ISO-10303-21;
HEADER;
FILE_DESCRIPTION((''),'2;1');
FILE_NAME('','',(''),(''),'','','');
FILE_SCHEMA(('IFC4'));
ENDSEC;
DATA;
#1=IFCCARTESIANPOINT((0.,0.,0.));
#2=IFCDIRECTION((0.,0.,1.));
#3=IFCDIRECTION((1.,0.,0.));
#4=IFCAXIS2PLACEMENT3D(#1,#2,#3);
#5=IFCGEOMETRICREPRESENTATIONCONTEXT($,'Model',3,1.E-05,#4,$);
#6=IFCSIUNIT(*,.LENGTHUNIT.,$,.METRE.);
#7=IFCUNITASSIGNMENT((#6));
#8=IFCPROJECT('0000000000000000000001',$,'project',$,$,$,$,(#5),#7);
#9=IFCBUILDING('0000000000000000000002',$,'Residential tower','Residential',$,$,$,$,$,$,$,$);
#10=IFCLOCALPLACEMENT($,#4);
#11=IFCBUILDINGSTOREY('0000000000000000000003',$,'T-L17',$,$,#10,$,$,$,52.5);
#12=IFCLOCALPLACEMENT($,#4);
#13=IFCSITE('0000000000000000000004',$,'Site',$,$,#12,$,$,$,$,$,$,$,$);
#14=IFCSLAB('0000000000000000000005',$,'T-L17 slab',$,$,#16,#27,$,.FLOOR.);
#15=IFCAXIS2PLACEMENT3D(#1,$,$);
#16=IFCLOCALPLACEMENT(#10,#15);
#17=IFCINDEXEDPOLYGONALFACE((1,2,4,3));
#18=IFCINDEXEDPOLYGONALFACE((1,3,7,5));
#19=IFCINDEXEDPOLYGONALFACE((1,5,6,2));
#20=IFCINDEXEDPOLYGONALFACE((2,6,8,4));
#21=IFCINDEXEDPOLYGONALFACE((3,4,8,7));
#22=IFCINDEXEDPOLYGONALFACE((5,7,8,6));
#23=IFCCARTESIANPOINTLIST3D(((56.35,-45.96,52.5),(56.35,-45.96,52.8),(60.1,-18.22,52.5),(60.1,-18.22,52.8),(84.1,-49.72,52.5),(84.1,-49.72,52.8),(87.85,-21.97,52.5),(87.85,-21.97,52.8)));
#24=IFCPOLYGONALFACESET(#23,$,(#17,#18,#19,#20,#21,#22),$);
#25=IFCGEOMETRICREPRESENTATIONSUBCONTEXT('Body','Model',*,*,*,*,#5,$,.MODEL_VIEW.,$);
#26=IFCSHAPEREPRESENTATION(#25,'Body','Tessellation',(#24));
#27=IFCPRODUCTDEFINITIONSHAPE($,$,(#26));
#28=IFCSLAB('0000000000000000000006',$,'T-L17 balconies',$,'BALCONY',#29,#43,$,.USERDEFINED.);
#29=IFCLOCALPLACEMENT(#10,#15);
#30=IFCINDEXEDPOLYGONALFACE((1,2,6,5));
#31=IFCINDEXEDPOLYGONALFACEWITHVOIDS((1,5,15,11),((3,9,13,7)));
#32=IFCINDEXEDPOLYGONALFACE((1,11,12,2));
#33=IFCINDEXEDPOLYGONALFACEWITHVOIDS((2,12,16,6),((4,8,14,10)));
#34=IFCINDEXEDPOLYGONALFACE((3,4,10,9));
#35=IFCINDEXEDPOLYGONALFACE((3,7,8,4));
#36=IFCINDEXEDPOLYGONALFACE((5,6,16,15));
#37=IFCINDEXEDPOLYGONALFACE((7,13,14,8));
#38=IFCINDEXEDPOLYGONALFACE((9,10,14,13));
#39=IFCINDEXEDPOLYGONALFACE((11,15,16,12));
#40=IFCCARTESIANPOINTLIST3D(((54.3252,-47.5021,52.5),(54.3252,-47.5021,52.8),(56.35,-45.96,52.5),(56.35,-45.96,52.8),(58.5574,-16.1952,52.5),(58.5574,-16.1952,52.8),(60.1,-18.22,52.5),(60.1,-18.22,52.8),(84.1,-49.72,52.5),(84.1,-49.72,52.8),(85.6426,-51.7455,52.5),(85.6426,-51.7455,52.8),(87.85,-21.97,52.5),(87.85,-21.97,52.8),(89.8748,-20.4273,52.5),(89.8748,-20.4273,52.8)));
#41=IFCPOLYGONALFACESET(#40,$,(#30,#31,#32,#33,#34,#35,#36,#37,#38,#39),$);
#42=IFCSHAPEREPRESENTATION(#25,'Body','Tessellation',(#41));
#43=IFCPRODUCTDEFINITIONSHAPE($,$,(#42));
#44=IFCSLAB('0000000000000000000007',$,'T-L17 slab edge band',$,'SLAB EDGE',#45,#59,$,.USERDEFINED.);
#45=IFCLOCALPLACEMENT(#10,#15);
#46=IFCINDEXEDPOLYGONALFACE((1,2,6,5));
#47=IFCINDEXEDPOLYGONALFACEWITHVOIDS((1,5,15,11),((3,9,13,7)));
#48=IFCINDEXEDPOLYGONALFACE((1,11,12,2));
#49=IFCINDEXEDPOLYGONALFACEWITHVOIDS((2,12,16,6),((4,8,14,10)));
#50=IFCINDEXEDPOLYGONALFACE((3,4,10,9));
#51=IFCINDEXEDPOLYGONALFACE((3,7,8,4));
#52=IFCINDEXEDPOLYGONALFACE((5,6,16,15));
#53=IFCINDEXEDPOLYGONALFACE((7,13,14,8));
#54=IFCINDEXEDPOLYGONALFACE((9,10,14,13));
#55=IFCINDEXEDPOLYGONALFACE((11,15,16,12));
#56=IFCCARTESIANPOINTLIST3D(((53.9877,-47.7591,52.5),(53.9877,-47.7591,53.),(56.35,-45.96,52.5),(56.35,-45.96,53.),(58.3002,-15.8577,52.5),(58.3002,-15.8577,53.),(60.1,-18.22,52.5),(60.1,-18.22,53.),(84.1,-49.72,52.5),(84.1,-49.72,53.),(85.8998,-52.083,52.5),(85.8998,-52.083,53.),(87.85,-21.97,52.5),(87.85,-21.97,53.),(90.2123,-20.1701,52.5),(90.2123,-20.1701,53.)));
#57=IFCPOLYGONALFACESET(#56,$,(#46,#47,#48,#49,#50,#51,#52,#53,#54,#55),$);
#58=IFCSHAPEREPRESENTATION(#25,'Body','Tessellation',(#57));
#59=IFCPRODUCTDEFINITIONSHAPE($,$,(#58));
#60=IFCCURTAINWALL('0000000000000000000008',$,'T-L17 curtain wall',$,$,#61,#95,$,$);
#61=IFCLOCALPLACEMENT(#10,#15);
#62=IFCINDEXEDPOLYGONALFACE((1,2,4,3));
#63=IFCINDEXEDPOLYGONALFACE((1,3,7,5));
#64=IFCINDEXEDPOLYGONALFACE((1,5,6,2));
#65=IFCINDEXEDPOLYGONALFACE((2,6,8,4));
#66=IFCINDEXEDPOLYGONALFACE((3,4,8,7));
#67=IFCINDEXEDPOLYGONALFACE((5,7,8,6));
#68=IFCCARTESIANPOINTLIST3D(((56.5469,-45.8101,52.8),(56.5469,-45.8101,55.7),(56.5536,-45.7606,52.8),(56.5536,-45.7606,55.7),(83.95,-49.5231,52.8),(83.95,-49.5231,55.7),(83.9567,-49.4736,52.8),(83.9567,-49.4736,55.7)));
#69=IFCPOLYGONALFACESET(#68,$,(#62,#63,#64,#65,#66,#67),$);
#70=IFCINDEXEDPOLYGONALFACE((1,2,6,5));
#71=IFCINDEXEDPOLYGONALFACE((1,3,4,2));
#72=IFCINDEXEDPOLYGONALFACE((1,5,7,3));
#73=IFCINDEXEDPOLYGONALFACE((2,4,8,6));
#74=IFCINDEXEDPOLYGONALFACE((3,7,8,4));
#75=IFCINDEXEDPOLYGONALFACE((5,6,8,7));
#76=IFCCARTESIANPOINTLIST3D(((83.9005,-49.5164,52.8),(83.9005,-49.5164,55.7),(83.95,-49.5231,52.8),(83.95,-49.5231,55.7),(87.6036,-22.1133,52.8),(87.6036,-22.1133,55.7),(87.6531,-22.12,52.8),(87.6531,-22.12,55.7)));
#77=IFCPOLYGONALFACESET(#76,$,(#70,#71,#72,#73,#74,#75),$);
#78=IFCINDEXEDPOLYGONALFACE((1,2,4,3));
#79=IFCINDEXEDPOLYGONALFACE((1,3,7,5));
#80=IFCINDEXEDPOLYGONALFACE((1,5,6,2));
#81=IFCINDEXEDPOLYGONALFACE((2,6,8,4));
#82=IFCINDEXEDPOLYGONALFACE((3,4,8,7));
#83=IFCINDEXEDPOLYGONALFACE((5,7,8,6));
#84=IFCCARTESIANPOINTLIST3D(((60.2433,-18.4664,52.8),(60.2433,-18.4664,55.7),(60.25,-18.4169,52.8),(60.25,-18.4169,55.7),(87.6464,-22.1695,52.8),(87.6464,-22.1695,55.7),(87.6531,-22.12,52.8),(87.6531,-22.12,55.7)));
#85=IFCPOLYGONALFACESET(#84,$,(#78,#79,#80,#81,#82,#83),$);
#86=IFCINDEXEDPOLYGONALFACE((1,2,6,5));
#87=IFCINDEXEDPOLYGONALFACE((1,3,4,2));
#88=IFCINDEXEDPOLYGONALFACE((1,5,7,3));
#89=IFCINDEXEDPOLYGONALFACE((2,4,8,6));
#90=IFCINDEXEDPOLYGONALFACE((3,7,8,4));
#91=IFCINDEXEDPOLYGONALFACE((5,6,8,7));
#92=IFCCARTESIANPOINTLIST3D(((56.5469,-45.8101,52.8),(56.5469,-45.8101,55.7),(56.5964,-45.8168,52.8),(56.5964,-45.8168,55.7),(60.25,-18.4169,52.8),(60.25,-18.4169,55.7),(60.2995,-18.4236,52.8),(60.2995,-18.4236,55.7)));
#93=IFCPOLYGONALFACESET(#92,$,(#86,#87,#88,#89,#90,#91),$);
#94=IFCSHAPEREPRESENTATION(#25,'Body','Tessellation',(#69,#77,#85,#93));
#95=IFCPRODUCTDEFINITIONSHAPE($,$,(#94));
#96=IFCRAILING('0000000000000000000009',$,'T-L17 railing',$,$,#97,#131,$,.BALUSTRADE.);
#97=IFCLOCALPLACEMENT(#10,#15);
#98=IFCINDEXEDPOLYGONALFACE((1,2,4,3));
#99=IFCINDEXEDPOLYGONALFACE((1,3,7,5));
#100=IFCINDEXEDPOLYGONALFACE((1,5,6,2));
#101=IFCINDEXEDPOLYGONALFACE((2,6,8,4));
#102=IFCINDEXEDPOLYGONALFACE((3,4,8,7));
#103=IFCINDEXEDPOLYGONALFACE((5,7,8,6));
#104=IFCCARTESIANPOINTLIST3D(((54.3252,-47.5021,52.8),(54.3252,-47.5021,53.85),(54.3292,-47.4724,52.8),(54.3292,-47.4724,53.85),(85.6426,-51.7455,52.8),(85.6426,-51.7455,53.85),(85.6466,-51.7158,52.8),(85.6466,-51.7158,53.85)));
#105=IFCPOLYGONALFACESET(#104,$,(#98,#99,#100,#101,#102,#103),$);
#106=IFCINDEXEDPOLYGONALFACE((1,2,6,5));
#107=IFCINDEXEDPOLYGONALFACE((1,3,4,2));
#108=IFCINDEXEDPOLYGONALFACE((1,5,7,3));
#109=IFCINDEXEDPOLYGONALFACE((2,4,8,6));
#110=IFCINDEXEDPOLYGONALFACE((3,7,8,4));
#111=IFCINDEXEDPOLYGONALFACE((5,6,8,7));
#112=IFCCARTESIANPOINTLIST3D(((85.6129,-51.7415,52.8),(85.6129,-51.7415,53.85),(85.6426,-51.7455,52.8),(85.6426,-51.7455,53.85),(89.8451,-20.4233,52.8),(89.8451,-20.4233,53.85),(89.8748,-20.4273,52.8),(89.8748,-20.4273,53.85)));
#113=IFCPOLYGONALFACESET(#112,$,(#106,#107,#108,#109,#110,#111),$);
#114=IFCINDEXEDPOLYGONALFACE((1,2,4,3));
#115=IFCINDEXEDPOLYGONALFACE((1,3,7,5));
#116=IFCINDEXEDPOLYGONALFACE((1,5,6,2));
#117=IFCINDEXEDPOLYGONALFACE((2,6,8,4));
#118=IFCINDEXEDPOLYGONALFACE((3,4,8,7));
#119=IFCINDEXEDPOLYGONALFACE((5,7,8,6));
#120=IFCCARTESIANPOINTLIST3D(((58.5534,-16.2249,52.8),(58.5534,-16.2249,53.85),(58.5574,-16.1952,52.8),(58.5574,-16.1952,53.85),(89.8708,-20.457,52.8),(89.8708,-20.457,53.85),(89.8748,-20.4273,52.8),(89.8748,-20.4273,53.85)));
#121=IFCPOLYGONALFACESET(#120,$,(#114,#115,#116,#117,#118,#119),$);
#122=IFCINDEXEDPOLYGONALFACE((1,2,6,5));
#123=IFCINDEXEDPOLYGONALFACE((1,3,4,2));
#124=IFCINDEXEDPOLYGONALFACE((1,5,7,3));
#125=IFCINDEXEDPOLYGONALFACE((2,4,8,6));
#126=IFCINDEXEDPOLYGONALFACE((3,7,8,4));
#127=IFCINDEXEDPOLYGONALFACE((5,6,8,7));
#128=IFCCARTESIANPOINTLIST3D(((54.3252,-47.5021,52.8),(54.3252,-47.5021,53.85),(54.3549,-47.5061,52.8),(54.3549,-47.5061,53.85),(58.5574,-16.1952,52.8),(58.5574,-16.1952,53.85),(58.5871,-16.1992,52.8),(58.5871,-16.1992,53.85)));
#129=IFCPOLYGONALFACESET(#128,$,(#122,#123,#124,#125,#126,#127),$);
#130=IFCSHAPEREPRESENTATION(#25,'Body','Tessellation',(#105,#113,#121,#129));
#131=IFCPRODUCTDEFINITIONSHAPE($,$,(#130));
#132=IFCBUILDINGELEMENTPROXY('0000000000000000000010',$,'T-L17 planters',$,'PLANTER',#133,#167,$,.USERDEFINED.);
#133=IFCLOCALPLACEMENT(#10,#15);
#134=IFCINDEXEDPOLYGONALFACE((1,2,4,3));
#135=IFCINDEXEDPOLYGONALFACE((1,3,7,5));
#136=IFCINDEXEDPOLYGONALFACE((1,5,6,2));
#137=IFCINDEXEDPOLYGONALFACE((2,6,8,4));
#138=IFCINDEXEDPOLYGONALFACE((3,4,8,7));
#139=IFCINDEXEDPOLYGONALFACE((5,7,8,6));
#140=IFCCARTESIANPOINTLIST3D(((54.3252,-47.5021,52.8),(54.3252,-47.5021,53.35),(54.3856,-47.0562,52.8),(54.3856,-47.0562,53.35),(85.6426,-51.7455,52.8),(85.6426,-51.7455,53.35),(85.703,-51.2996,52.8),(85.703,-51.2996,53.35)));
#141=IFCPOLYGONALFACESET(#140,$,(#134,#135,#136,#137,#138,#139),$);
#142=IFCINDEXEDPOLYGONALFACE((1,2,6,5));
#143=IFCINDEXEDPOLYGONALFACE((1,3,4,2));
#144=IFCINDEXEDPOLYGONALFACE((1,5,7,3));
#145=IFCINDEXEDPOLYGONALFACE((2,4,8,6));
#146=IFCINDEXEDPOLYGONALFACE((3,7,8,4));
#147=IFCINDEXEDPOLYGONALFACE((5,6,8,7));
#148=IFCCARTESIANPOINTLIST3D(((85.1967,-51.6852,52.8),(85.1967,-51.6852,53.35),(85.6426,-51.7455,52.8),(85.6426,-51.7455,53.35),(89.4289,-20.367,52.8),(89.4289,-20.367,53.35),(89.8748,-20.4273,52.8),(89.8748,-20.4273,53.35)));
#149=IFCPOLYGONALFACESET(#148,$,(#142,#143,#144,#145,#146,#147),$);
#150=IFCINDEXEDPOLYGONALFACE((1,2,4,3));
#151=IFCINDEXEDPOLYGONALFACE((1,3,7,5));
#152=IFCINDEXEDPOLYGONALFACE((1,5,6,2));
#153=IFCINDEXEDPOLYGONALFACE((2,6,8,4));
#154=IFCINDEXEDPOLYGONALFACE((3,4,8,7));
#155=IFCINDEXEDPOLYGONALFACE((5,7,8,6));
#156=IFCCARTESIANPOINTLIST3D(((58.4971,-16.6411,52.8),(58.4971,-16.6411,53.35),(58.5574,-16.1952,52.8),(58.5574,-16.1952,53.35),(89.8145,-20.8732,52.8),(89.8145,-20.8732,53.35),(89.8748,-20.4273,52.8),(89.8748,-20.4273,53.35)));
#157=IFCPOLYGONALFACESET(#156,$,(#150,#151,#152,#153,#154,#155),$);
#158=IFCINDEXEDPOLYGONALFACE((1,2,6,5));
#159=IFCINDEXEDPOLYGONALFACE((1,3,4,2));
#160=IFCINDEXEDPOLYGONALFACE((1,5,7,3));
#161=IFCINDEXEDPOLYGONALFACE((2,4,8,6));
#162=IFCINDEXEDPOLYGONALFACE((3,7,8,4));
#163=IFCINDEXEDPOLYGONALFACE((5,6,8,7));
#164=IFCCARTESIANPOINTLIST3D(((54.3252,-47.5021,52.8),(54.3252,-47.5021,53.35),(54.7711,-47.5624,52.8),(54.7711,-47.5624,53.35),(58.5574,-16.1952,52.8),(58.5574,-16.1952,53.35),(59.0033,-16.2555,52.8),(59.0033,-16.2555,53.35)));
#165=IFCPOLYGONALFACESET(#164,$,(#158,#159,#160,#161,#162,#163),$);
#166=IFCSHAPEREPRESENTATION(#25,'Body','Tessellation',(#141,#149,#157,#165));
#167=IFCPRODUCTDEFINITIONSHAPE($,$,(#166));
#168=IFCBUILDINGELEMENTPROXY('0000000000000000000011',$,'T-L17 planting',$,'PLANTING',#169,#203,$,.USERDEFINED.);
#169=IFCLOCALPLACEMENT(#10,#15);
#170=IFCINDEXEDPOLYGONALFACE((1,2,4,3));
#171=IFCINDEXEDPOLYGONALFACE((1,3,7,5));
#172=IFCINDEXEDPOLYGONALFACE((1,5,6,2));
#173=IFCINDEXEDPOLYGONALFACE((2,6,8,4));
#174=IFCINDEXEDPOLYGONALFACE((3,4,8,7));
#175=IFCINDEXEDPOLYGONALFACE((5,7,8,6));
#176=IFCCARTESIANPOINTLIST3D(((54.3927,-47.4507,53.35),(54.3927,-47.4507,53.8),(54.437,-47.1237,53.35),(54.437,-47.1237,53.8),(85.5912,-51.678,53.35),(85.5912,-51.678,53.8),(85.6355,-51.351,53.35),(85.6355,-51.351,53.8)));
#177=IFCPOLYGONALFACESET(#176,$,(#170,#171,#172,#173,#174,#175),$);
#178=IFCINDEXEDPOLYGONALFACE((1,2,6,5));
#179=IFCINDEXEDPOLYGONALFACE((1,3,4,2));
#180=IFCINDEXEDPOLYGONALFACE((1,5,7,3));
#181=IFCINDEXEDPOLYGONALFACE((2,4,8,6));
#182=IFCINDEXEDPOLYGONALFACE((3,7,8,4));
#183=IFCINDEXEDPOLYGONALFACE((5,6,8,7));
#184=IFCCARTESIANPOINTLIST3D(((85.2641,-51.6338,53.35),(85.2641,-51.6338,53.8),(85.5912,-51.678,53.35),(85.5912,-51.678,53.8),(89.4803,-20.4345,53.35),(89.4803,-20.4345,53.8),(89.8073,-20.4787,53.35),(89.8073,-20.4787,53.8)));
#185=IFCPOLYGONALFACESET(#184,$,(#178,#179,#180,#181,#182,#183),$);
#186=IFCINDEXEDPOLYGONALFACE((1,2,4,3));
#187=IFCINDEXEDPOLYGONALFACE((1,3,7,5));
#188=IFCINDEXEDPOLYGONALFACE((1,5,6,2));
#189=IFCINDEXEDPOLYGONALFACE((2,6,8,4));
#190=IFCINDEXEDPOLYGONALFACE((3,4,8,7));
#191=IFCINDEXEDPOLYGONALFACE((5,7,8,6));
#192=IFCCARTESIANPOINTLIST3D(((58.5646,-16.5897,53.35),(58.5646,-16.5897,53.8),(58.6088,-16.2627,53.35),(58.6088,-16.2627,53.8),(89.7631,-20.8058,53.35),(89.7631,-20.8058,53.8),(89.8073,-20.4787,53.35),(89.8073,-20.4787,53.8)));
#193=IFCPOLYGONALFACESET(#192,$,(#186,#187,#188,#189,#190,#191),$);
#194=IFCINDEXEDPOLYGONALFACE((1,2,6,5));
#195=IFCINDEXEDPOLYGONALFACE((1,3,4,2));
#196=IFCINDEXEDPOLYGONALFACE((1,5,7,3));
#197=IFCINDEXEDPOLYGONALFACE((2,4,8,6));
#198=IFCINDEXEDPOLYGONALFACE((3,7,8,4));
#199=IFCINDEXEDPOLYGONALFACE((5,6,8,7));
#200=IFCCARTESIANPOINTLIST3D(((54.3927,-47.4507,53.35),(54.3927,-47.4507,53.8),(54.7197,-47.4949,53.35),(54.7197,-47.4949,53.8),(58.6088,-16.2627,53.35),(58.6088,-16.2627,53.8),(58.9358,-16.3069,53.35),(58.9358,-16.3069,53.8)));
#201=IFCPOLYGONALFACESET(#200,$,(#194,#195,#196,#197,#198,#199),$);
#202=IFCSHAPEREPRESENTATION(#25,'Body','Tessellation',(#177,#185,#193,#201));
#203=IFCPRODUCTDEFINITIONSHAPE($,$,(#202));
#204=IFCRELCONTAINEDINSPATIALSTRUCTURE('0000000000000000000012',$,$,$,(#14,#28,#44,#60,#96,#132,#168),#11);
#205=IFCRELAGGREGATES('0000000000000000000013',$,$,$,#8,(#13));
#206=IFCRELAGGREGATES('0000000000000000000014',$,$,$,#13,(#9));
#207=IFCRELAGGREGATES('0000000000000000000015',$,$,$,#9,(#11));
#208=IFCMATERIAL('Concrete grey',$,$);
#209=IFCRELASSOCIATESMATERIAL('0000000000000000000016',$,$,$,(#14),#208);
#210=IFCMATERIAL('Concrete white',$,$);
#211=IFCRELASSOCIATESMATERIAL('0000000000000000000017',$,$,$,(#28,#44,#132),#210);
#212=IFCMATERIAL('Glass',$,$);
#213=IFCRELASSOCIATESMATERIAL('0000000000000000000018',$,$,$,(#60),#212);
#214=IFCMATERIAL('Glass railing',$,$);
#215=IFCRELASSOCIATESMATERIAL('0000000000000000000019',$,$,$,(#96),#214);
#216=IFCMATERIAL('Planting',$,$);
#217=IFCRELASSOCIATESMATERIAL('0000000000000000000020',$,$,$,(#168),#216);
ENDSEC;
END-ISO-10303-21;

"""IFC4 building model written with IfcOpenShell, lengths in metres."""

from ifc_helpers import new_model, si_unit, frame, origin_with_axes, place, context, subcontext, project, spatial, polyline, outline, extrude, material, element, save


model = new_model("IFC4")

# Units and contexts
model_context = context("Model", 3, precision=1e-05, world=origin_with_axes())
body_context = subcontext(model_context, "Body", "Model", "MODEL_VIEW")
ifc_project = project(units=[si_unit("LENGTHUNIT", "METRE")], contexts=[model_context])

# Site, building, storey
site_placement = place(None, origin_with_axes())
site = spatial("IfcSite", under=ifc_project, at=site_placement, Name="Site")
building = spatial("IfcBuilding", under=site, Name="Residential tower", Description="Residential")
storey_placement = place(None, origin_with_axes())
storey = spatial("IfcBuildingStorey", under=building, at=storey_placement, Name="T-L17", Elevation=52.5)

# Slabs
ifc_material_1 = material(Name="Concrete grey")
slab_1_placement = place(storey_placement, origin_with_axes())
element("IfcSlab", 1, at=slab_1_placement, inside=storey, material=ifc_material_1, Name="T-L17 slab", PredefinedType="FLOOR", context=body_context, shape_type="SweptSolid", body=[
    extrude(outline(polyline([(56.35, -45.96), (84.1, -49.72), (87.85, -21.97), (60.1, -18.22), (56.35, -45.96)])), frame((0.0, 0.0, 52.5), z_axis=(0.0, 0.0, 1.0), x_axis=(1.0, 0.0, 0.0)), (0.0, 0.0, 1.0), 0.3),
])
ifc_material_2 = material(Name="Concrete white")
slab_2_placement = place(storey_placement, origin_with_axes())
element("IfcSlab", 2, at=slab_2_placement, inside=storey, material=ifc_material_2, Name="T-L17 balconies", ObjectType="BALCONY", PredefinedType="USERDEFINED", context=body_context, shape_type="SweptSolid", body=[
    extrude(outline(polyline([(54.3252, -47.5021), (85.6426, -51.7455), (89.8748, -20.4273), (58.5574, -16.1952), (54.3252, -47.5021)]), holes=[polyline([(56.35, -45.96), (84.1, -49.72), (87.85, -21.97), (60.1, -18.22), (56.35, -45.96)])]), frame((0.0, 0.0, 52.5), z_axis=(0.0, 0.0, 1.0), x_axis=(1.0, 0.0, 0.0)), (0.0, 0.0, 1.0), 0.3),
])
slab_3_placement = place(storey_placement, origin_with_axes())
element("IfcSlab", 3, at=slab_3_placement, inside=storey, material=ifc_material_2, Name="T-L17 slab edge band", ObjectType="SLAB EDGE", PredefinedType="USERDEFINED", context=body_context, shape_type="SweptSolid", body=[
    extrude(outline(polyline([(53.9877, -47.7591), (85.8998, -52.083), (90.2123, -20.1701), (58.3002, -15.8577), (53.9877, -47.7591)]), holes=[polyline([(56.35, -45.96), (84.1, -49.72), (87.85, -21.97), (60.1, -18.22), (56.35, -45.96)])]), frame((0.0, 0.0, 52.5), z_axis=(0.0, 0.0, 1.0), x_axis=(1.0, 0.0, 0.0)), (0.0, 0.0, 1.0), 0.5),
])

# Curtain wall
ifc_material_3 = material(Name="Glass")
curtain_wall_placement = place(storey_placement, origin_with_axes())
element("IfcCurtainWall", 4, at=curtain_wall_placement, inside=storey, material=ifc_material_3, Name="T-L17 curtain wall", context=body_context, shape_type="SweptSolid", body=[
    extrude(outline(polyline([(56.5469, -45.8101), (83.95, -49.5231), (83.9567, -49.4736), (56.5536, -45.7606), (56.5469, -45.8101)])), frame((0.0, 0.0, 52.8), z_axis=(0.0, 0.0, 1.0), x_axis=(1.0, 0.0, 0.0)), (0.0, 0.0, 1.0), 2.9),
    extrude(outline(polyline([(83.95, -49.5231), (87.6531, -22.12), (87.6036, -22.1133), (83.9005, -49.5164), (83.95, -49.5231)])), frame((0.0, 0.0, 52.8), z_axis=(0.0, 0.0, 1.0), x_axis=(1.0, 0.0, 0.0)), (0.0, 0.0, 1.0), 2.9),
    extrude(outline(polyline([(87.6531, -22.12), (60.25, -18.4169), (60.2433, -18.4664), (87.6464, -22.1695), (87.6531, -22.12)])), frame((0.0, 0.0, 52.8), z_axis=(0.0, 0.0, 1.0), x_axis=(1.0, 0.0, 0.0)), (0.0, 0.0, 1.0), 2.9),
    extrude(outline(polyline([(60.25, -18.4169), (56.5469, -45.8101), (56.5964, -45.8168), (60.2995, -18.4236), (60.25, -18.4169)])), frame((0.0, 0.0, 52.8), z_axis=(0.0, 0.0, 1.0), x_axis=(1.0, 0.0, 0.0)), (0.0, 0.0, 1.0), 2.9),
])

# Railing
ifc_material_4 = material(Name="Glass railing")
railing_placement = place(storey_placement, origin_with_axes())
element("IfcRailing", 5, at=railing_placement, inside=storey, material=ifc_material_4, Name="T-L17 railing", PredefinedType="BALUSTRADE", context=body_context, shape_type="SweptSolid", body=[
    extrude(outline(polyline([(54.3252, -47.5021), (85.6426, -51.7455), (85.6466, -51.7158), (54.3292, -47.4724), (54.3252, -47.5021)])), frame((0.0, 0.0, 52.8), z_axis=(0.0, 0.0, 1.0), x_axis=(1.0, 0.0, 0.0)), (0.0, 0.0, 1.0), 1.05),
    extrude(outline(polyline([(85.6426, -51.7455), (89.8748, -20.4273), (89.8451, -20.4233), (85.6129, -51.7415), (85.6426, -51.7455)])), frame((0.0, 0.0, 52.8), z_axis=(0.0, 0.0, 1.0), x_axis=(1.0, 0.0, 0.0)), (0.0, 0.0, 1.0), 1.05),
    extrude(outline(polyline([(89.8748, -20.4273), (58.5574, -16.1952), (58.5534, -16.2249), (89.8708, -20.457), (89.8748, -20.4273)])), frame((0.0, 0.0, 52.8), z_axis=(0.0, 0.0, 1.0), x_axis=(1.0, 0.0, 0.0)), (0.0, 0.0, 1.0), 1.05),
    extrude(outline(polyline([(58.5574, -16.1952), (54.3252, -47.5021), (54.3549, -47.5061), (58.5871, -16.1992), (58.5574, -16.1952)])), frame((0.0, 0.0, 52.8), z_axis=(0.0, 0.0, 1.0), x_axis=(1.0, 0.0, 0.0)), (0.0, 0.0, 1.0), 1.05),
])

# Building element proxies
proxy_1_placement = place(storey_placement, origin_with_axes())
element("IfcBuildingElementProxy", 6, at=proxy_1_placement, inside=storey, material=ifc_material_2, Name="T-L17 planters", ObjectType="PLANTER", PredefinedType="USERDEFINED", context=body_context, shape_type="SweptSolid", body=[
    extrude(outline(polyline([(54.3252, -47.5021), (85.6426, -51.7455), (85.703, -51.2996), (54.3856, -47.0562), (54.3252, -47.5021)])), frame((0.0, 0.0, 52.8), z_axis=(0.0, 0.0, 1.0), x_axis=(1.0, 0.0, 0.0)), (0.0, 0.0, 1.0), 0.55),
    extrude(outline(polyline([(85.6426, -51.7455), (89.8748, -20.4273), (89.4289, -20.367), (85.1967, -51.6852), (85.6426, -51.7455)])), frame((0.0, 0.0, 52.8), z_axis=(0.0, 0.0, 1.0), x_axis=(1.0, 0.0, 0.0)), (0.0, 0.0, 1.0), 0.55),
    extrude(outline(polyline([(89.8748, -20.4273), (58.5574, -16.1952), (58.4971, -16.6411), (89.8145, -20.8732), (89.8748, -20.4273)])), frame((0.0, 0.0, 52.8), z_axis=(0.0, 0.0, 1.0), x_axis=(1.0, 0.0, 0.0)), (0.0, 0.0, 1.0), 0.55),
    extrude(outline(polyline([(58.5574, -16.1952), (54.3252, -47.5021), (54.7711, -47.5624), (59.0033, -16.2555), (58.5574, -16.1952)])), frame((0.0, 0.0, 52.8), z_axis=(0.0, 0.0, 1.0), x_axis=(1.0, 0.0, 0.0)), (0.0, 0.0, 1.0), 0.55),
])
ifc_material_5 = material(Name="Planting")
proxy_2_placement = place(storey_placement, origin_with_axes())
element("IfcBuildingElementProxy", 7, at=proxy_2_placement, inside=storey, material=ifc_material_5, Name="T-L17 planting", ObjectType="PLANTING", PredefinedType="USERDEFINED", context=body_context, shape_type="SweptSolid", body=[
    extrude(outline(polyline([(54.3927, -47.4507), (85.5912, -51.678), (85.6355, -51.351), (54.437, -47.1237), (54.3927, -47.4507)])), frame((0.0, 0.0, 53.35), z_axis=(0.0, 0.0, 1.0), x_axis=(1.0, 0.0, 0.0)), (0.0, 0.0, 1.0), 0.45),
    extrude(outline(polyline([(85.5912, -51.678), (89.8073, -20.4787), (89.4803, -20.4345), (85.2641, -51.6338), (85.5912, -51.678)])), frame((0.0, 0.0, 53.35), z_axis=(0.0, 0.0, 1.0), x_axis=(1.0, 0.0, 0.0)), (0.0, 0.0, 1.0), 0.45),
    extrude(outline(polyline([(89.8073, -20.4787), (58.6088, -16.2627), (58.5646, -16.5897), (89.7631, -20.8058), (89.8073, -20.4787)])), frame((0.0, 0.0, 53.35), z_axis=(0.0, 0.0, 1.0), x_axis=(1.0, 0.0, 0.0)), (0.0, 0.0, 1.0), 0.45),
    extrude(outline(polyline([(58.6088, -16.2627), (54.3927, -47.4507), (54.7197, -47.4949), (58.9358, -16.3069), (58.6088, -16.2627)])), frame((0.0, 0.0, 53.35), z_axis=(0.0, 0.0, 1.0), x_axis=(1.0, 0.0, 0.0)), (0.0, 0.0, 1.0), 0.45),
])

save(model, "model.ifc")
